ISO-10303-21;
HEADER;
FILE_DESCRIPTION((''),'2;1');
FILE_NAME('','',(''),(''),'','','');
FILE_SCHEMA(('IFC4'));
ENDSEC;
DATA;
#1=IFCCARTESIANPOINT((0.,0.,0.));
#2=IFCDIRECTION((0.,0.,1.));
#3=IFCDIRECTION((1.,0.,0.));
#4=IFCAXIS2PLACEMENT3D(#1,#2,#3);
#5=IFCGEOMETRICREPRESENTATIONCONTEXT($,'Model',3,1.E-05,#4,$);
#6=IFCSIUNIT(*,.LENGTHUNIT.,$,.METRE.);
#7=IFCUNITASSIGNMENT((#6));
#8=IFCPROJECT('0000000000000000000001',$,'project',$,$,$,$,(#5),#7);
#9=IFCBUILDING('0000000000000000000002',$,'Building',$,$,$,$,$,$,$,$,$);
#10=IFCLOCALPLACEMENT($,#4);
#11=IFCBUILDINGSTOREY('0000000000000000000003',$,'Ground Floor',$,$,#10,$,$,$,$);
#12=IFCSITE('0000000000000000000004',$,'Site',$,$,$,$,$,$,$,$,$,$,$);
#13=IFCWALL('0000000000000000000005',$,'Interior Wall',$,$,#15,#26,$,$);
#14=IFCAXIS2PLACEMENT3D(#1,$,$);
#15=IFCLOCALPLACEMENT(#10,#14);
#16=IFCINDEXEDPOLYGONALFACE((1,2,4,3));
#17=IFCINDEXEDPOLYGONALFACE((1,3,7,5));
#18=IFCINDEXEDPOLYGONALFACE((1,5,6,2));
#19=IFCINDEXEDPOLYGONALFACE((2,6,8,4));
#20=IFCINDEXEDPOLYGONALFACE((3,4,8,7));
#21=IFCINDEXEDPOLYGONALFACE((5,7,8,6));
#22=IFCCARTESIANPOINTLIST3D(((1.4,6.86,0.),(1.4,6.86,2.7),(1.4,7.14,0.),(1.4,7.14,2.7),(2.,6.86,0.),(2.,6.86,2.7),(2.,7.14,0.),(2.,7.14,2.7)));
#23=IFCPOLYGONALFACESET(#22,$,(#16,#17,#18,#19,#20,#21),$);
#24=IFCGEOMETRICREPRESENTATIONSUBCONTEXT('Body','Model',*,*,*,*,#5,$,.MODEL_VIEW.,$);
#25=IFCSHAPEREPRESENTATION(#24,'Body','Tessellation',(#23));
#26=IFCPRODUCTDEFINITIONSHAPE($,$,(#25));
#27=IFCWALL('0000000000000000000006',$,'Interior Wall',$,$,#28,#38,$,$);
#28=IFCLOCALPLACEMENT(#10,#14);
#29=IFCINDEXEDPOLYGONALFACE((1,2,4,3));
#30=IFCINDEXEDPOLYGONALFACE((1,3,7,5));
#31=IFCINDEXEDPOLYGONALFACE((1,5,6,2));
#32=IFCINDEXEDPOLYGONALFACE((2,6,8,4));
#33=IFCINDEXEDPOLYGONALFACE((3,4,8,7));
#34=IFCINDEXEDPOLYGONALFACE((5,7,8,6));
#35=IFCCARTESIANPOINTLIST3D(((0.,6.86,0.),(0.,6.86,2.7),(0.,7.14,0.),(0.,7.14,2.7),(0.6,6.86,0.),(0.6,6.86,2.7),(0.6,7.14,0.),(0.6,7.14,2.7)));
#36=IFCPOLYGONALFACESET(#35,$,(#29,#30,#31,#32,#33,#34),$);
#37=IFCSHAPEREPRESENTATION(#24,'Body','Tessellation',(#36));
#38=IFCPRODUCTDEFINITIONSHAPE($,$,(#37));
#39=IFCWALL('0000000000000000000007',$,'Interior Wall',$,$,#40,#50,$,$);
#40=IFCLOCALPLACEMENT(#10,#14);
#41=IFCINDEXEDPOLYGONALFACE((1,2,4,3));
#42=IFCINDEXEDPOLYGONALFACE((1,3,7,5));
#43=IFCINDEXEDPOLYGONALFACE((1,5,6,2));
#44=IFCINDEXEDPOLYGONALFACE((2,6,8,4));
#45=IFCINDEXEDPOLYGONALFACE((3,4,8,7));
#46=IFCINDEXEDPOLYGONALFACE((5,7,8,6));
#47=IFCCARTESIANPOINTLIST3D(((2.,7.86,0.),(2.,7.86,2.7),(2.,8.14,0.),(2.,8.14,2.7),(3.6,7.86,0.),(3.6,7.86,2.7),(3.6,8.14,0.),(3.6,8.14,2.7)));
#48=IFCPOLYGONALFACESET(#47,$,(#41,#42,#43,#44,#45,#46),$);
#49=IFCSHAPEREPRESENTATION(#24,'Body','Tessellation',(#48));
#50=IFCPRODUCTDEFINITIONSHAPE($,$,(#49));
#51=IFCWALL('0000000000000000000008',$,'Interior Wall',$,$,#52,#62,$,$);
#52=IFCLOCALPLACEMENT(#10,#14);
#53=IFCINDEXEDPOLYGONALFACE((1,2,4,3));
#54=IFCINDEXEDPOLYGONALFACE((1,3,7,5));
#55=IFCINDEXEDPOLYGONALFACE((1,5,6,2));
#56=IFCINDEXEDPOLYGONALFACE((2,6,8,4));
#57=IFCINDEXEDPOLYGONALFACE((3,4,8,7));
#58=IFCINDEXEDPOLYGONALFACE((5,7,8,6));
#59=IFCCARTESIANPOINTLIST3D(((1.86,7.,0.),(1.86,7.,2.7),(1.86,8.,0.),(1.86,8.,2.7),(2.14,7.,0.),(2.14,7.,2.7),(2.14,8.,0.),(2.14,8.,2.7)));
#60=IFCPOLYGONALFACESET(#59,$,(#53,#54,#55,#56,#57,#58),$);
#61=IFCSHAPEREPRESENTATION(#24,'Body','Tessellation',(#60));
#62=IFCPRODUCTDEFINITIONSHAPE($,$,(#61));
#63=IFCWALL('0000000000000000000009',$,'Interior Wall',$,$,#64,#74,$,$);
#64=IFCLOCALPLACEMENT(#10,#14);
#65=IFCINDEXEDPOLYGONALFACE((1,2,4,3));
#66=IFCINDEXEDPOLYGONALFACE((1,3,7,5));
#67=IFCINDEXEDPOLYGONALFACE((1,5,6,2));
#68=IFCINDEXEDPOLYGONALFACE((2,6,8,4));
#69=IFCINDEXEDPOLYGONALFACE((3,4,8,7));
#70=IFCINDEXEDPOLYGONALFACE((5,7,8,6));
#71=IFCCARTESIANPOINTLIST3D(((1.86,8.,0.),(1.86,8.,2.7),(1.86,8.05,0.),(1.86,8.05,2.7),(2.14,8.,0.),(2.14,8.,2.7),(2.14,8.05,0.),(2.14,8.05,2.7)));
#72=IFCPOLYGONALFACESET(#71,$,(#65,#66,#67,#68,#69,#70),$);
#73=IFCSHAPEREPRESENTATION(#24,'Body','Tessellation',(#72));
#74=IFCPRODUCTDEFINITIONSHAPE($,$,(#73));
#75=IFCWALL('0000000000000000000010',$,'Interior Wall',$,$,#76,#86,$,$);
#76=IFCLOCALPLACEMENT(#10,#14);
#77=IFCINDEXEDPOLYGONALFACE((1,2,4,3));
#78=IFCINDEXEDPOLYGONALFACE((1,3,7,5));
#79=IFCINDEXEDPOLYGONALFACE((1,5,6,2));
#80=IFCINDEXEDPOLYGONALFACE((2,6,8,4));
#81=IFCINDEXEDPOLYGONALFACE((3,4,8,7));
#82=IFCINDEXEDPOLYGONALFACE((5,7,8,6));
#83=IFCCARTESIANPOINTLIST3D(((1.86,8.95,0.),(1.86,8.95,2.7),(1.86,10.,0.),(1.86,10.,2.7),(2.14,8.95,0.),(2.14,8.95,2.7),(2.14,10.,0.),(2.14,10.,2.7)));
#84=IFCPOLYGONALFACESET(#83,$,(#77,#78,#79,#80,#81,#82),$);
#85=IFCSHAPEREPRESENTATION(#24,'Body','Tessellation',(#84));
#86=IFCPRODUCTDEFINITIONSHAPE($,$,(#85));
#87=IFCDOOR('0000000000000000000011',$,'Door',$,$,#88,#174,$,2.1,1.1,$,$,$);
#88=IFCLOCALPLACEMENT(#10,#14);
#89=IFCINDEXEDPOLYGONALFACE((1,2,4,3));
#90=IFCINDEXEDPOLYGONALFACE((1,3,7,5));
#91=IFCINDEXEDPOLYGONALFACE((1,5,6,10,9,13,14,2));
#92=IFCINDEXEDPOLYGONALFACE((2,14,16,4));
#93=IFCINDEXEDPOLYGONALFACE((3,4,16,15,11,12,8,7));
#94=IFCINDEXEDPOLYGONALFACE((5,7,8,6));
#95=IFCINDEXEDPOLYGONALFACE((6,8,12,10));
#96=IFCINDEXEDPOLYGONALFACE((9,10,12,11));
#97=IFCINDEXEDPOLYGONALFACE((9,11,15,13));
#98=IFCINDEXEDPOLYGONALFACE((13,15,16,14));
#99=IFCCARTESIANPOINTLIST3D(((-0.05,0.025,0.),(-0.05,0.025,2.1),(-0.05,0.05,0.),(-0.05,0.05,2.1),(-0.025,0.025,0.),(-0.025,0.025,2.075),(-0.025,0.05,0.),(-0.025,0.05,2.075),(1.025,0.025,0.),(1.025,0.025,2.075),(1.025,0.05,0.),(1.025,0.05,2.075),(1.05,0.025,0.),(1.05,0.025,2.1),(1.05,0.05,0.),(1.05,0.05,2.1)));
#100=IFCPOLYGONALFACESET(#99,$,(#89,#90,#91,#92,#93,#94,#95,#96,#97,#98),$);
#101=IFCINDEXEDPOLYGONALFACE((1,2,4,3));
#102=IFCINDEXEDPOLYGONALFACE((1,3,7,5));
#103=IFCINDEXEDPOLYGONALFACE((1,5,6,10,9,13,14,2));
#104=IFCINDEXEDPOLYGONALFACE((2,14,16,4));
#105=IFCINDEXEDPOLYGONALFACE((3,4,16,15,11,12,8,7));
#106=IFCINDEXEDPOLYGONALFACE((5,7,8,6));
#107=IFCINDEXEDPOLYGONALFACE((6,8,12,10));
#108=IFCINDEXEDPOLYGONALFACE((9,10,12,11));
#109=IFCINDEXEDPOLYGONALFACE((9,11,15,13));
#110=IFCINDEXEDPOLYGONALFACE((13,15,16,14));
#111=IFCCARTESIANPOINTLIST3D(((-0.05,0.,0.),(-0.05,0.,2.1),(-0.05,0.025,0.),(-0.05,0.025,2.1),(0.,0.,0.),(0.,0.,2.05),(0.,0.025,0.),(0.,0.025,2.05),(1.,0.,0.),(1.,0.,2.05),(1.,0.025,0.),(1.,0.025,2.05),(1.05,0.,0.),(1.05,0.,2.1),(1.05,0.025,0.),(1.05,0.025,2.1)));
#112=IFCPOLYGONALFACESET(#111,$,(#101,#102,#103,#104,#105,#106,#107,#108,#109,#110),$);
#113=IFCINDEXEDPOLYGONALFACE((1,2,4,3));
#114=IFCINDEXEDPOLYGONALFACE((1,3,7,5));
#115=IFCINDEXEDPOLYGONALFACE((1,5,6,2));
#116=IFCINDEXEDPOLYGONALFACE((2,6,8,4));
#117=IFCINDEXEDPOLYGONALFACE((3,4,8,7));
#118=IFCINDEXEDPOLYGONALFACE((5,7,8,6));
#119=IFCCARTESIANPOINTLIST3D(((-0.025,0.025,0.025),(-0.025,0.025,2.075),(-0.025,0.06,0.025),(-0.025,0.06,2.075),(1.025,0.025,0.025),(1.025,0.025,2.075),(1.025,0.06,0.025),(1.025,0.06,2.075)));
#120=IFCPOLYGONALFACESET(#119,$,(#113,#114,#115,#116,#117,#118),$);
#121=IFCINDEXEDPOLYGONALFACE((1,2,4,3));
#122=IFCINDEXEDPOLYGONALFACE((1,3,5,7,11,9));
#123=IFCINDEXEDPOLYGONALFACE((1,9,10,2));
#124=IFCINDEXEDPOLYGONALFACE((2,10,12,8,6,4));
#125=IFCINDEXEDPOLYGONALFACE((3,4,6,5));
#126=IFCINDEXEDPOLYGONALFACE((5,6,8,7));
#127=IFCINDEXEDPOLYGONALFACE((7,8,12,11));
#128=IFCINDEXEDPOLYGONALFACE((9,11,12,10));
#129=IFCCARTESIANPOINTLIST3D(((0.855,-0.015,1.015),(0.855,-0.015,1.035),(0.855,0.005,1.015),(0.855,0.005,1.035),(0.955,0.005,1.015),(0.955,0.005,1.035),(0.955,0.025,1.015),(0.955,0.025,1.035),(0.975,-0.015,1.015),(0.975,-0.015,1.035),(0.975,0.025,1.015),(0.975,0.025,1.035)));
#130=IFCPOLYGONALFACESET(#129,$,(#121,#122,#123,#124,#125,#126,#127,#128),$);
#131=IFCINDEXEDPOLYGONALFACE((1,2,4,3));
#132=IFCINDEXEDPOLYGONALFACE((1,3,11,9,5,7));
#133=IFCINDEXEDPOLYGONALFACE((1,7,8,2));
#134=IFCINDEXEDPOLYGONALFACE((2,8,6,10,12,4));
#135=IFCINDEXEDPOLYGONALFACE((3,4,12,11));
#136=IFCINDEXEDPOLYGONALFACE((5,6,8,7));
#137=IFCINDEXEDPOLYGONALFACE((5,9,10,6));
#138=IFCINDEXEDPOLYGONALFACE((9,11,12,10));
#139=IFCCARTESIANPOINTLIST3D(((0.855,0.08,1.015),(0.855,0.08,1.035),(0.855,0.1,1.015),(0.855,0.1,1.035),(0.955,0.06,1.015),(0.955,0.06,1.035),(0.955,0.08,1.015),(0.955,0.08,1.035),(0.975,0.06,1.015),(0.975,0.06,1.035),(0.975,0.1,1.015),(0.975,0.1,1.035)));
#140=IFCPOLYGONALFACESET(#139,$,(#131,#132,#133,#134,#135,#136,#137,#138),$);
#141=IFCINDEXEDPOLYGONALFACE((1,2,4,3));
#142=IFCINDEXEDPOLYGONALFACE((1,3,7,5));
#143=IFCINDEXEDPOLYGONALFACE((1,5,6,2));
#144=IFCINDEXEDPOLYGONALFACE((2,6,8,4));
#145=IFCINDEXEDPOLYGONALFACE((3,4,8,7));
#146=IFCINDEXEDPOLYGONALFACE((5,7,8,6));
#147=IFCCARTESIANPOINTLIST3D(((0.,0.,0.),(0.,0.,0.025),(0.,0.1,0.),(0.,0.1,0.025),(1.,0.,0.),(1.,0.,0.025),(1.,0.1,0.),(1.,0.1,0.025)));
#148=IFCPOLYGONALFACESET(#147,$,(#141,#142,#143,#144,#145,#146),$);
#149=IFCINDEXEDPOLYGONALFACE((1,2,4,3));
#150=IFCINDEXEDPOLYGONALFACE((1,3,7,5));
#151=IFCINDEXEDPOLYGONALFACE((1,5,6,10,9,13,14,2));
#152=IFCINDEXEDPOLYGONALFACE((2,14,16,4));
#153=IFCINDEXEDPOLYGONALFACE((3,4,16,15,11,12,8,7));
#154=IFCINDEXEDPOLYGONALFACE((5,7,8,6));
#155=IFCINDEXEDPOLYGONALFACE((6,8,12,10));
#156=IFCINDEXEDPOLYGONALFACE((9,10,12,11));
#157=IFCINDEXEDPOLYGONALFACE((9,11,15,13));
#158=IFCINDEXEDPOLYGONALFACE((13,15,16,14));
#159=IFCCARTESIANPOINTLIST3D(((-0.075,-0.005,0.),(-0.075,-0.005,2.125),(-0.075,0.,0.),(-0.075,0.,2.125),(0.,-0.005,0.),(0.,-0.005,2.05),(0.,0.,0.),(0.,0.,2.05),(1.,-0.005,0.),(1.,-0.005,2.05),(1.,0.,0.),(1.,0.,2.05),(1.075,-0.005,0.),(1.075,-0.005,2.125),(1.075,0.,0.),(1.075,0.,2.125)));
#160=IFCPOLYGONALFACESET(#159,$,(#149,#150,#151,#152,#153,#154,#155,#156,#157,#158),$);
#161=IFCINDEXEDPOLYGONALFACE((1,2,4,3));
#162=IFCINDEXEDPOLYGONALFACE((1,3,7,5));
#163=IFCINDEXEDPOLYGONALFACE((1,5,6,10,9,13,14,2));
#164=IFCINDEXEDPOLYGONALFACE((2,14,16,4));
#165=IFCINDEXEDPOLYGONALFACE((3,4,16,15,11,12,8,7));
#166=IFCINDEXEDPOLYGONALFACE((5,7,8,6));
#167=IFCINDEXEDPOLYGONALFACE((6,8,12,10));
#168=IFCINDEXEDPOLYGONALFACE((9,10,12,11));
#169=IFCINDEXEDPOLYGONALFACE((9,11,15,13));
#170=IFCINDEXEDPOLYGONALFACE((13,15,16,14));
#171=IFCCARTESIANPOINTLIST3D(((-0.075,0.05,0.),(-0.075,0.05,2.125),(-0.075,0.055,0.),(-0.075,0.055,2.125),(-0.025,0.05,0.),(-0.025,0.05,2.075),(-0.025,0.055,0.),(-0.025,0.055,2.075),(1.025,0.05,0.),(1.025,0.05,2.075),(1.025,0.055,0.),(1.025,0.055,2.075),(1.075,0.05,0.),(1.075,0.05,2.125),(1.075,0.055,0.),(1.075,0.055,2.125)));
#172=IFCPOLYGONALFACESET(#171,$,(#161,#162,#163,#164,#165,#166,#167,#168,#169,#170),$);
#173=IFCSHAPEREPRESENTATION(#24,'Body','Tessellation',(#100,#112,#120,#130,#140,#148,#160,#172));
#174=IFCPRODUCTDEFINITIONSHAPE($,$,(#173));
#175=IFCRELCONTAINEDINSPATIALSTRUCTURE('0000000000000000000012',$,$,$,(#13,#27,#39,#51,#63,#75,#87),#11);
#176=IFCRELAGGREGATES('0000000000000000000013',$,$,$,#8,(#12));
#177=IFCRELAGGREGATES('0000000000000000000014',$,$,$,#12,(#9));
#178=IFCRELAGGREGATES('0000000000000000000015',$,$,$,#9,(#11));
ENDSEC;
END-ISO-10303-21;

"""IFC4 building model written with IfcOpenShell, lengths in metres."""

from ifc_helpers import new_model, si_unit, frame, origin_with_axes, place, context, subcontext, project, spatial, line, indexed_curve, outline, extrude, element, save


model = new_model("IFC4")

# Units and contexts
model_context = context("Model", 3, precision=1e-05, world=origin_with_axes())
body_context = subcontext(model_context, "Body", "Model", "MODEL_VIEW")
ifc_project = project(units=[si_unit("LENGTHUNIT", "METRE")], contexts=[model_context])

# Site, building, storey
site = spatial("IfcSite", under=ifc_project, Name="Site")
building = spatial("IfcBuilding", under=site, Name="Building")
storey_placement = place(None, origin_with_axes())
storey = spatial("IfcBuildingStorey", under=building, at=storey_placement, Name="Ground Floor")

# Walls
for number, where, z_axis, x_axis, name in (
    (1, (2.0, 7.0, 0.0), (0.0, 0.0, 1.0), (-1.0, 0.0, 0.0), "Interior Wall"),
    (2, (0.6, 7.0, 0.0), (0.0, 0.0, 1.0), (-1.0, 0.0, 0.0), "Interior Wall"),
):
    element("IfcWall", number, at=place(storey_placement, frame(where, z_axis=z_axis, x_axis=x_axis)), inside=storey, Name=name, context=body_context, shape_type="SweptSolid", body=[
        extrude(outline(indexed_curve([(0.0, 0.0), (0.0, 0.28), (0.6, 0.28), (0.6, 0.0), (0.0, 0.0)], self_intersect=False)), frame((0.0, -0.14, 0.0), z_axis=(0.0, 0.0, 1.0), x_axis=(1.0, 0.0, 0.0)), (0.0, 0.0, 1.0), 2.7),
    ])
wall_1_placement = place(storey_placement, frame((3.6, 8.0, 0.0), z_axis=(0.0, 0.0, 1.0), x_axis=(-1.0, 0.0, 0.0)))
element("IfcWall", 3, at=wall_1_placement, inside=storey, Name="Interior Wall", context=body_context, shape_type="SweptSolid", body=[
    extrude(outline(indexed_curve([(0.0, 0.0), (0.0, 0.28), (1.6, 0.28), (1.6, 0.0), (0.0, 0.0)], self_intersect=False)), frame((0.0, -0.14, 0.0), z_axis=(0.0, 0.0, 1.0), x_axis=(1.0, 0.0, 0.0)), (0.0, 0.0, 1.0), 2.7),
])
wall_2_placement = place(storey_placement, frame((2.0, 8.0, 0.0), z_axis=(0.0, 0.0, 1.0), x_axis=(0.0, -1.0, 0.0)))
element("IfcWall", 4, at=wall_2_placement, inside=storey, Name="Interior Wall", context=body_context, shape_type="SweptSolid", body=[
    extrude(outline(indexed_curve([(0.0, 0.0), (0.0, 0.28), (1.0, 0.28), (1.0, 0.0), (0.0, 0.0)], self_intersect=False)), frame((0.0, -0.14, 0.0), z_axis=(0.0, 0.0, 1.0), x_axis=(1.0, 0.0, 0.0)), (0.0, 0.0, 1.0), 2.7),
])
wall_3_placement = place(storey_placement, frame((2.0, 8.0, 0.0), z_axis=(0.0, 0.0, 1.0), x_axis=(0.0, 1.0, 0.0)))
element("IfcWall", 5, at=wall_3_placement, inside=storey, Name="Interior Wall", context=body_context, shape_type="SweptSolid", body=[
    extrude(outline(indexed_curve([(0.0, 0.0), (0.0, 0.28), (0.05, 0.28), (0.05, 0.0), (0.0, 0.0)], self_intersect=False)), frame((0.0, -0.14, 0.0), z_axis=(0.0, 0.0, 1.0), x_axis=(1.0, 0.0, 0.0)), (0.0, 0.0, 1.0), 2.7),
])
wall_4_placement = place(storey_placement, frame((2.0, 8.95, 0.0), z_axis=(0.0, 0.0, 1.0), x_axis=(0.0, 1.0, 0.0)))
element("IfcWall", 6, at=wall_4_placement, inside=storey, Name="Interior Wall", context=body_context, shape_type="SweptSolid", body=[
    extrude(outline(indexed_curve([(0.0, 0.0), (0.0, 0.28), (1.05, 0.28), (1.05, 0.0), (0.0, 0.0)], self_intersect=False)), frame((0.0, -0.14, 0.0), z_axis=(0.0, 0.0, 1.0), x_axis=(1.0, 0.0, 0.0)), (0.0, 0.0, 1.0), 2.7),
])

# Door
door_1_placement = place(storey_placement, frame((-0.05, 0.0, 0.0), z_axis=(0.0, 0.0, 1.0), x_axis=(1.0, 0.0, 0.0)))
element("IfcDoor", 7, at=door_1_placement, inside=storey, Name="Door", OverallHeight=2.1, OverallWidth=1.1, context=body_context, shape_type="SweptSolid", body=[
    extrude(outline(indexed_curve([(0.0, 0.0), (0.0, 2.1), (1.1, 2.1), (1.1, 0.0), (1.075, 0.0), (1.075, 2.075), (0.025, 2.075), (0.025, 0.0)], segments=[line(1, 2, 3, 4, 5, 6, 7, 8, 1)])), frame((0.0, 0.025, 0.0), z_axis=(0.0, -1.0, 0.0), x_axis=(1.0, 0.0, 0.0)), (0.0, 0.0, -1.0), 0.025),
    extrude(outline(indexed_curve([(0.0, 0.0), (0.0, 2.1), (1.1, 2.1), (1.1, 0.0), (1.05, 0.0), (1.05, 2.05), (0.05, 2.05), (0.05, 0.0)], segments=[line(1, 2, 3, 4, 5, 6, 7, 8, 1)])), frame((0.0, 0.0, 0.0), z_axis=(0.0, -1.0, 0.0), x_axis=(1.0, 0.0, 0.0)), (0.0, 0.0, -1.0), 0.025),
    extrude(outline(indexed_curve([(0.0, 0.0), (1.05, 0.0), (1.05, 0.035), (0.0, 0.035)], segments=[line(1, 2, 3, 4, 1)])), frame((0.025, 0.025, 0.025), z_axis=(0.0, 0.0, 1.0), x_axis=(1.0, 0.0, 0.0)), (0.0, 0.0, 1.0), 2.05),
    extrude(outline(indexed_curve([(0.0, 0.0), (0.0, -0.04), (-0.12, -0.04), (-0.12, -0.02), (-0.02, -0.02), (-0.02, 0.0)], segments=[line(1, 2, 3, 4, 5, 6, 1)])), frame((1.025, 0.025, 1.015), z_axis=(0.0, 0.0, 1.0), x_axis=(1.0, 0.0, 0.0)), (0.0, 0.0, 1.0), 0.02),
    extrude(outline(indexed_curve([(0.0, 0.0), (0.0, 0.04), (-0.12, 0.04), (-0.12, 0.02), (-0.02, 0.02), (-0.02, 0.0)], segments=[line(1, 2, 3, 4, 5, 6, 1)])), frame((1.025, 0.06, 1.015), z_axis=(0.0, 0.0, 1.0), x_axis=(1.0, 0.0, 0.0)), (0.0, 0.0, 1.0), 0.02),
    extrude(outline(indexed_curve([(0.0, 0.0), (1.0, 0.0), (1.0, 0.1), (0.0, 0.1)], segments=[line(1, 2, 3, 4, 1)])), frame((0.05, 0.0, 0.0), z_axis=(0.0, 0.0, 1.0), x_axis=(1.0, 0.0, 0.0)), (0.0, 0.0, 1.0), 0.025),
    extrude(outline(indexed_curve([(0.0, 0.0), (0.0, 2.125), (1.15, 2.125), (1.15, 0.0), (1.075, 0.0), (1.075, 2.05), (0.075, 2.05), (0.075, 0.0)], segments=[line(1, 2, 3, 4, 5, 6, 7, 8, 1)])), frame((-0.025, -0.005, 0.0), z_axis=(0.0, -1.0, 0.0), x_axis=(1.0, 0.0, 0.0)), (0.0, 0.0, -1.0), 0.005),
    extrude(outline(indexed_curve([(0.0, 0.0), (0.0, 2.125), (1.15, 2.125), (1.15, 0.0), (1.1, 0.0), (1.1, 2.075), (0.05, 2.075), (0.05, 0.0)], segments=[line(1, 2, 3, 4, 5, 6, 7, 8, 1)])), frame((-0.025, 0.05, 0.0), z_axis=(0.0, -1.0, 0.0), x_axis=(1.0, 0.0, 0.0)), (0.0, 0.0, -1.0), 0.005),
])

save(model, "model.ifc")
